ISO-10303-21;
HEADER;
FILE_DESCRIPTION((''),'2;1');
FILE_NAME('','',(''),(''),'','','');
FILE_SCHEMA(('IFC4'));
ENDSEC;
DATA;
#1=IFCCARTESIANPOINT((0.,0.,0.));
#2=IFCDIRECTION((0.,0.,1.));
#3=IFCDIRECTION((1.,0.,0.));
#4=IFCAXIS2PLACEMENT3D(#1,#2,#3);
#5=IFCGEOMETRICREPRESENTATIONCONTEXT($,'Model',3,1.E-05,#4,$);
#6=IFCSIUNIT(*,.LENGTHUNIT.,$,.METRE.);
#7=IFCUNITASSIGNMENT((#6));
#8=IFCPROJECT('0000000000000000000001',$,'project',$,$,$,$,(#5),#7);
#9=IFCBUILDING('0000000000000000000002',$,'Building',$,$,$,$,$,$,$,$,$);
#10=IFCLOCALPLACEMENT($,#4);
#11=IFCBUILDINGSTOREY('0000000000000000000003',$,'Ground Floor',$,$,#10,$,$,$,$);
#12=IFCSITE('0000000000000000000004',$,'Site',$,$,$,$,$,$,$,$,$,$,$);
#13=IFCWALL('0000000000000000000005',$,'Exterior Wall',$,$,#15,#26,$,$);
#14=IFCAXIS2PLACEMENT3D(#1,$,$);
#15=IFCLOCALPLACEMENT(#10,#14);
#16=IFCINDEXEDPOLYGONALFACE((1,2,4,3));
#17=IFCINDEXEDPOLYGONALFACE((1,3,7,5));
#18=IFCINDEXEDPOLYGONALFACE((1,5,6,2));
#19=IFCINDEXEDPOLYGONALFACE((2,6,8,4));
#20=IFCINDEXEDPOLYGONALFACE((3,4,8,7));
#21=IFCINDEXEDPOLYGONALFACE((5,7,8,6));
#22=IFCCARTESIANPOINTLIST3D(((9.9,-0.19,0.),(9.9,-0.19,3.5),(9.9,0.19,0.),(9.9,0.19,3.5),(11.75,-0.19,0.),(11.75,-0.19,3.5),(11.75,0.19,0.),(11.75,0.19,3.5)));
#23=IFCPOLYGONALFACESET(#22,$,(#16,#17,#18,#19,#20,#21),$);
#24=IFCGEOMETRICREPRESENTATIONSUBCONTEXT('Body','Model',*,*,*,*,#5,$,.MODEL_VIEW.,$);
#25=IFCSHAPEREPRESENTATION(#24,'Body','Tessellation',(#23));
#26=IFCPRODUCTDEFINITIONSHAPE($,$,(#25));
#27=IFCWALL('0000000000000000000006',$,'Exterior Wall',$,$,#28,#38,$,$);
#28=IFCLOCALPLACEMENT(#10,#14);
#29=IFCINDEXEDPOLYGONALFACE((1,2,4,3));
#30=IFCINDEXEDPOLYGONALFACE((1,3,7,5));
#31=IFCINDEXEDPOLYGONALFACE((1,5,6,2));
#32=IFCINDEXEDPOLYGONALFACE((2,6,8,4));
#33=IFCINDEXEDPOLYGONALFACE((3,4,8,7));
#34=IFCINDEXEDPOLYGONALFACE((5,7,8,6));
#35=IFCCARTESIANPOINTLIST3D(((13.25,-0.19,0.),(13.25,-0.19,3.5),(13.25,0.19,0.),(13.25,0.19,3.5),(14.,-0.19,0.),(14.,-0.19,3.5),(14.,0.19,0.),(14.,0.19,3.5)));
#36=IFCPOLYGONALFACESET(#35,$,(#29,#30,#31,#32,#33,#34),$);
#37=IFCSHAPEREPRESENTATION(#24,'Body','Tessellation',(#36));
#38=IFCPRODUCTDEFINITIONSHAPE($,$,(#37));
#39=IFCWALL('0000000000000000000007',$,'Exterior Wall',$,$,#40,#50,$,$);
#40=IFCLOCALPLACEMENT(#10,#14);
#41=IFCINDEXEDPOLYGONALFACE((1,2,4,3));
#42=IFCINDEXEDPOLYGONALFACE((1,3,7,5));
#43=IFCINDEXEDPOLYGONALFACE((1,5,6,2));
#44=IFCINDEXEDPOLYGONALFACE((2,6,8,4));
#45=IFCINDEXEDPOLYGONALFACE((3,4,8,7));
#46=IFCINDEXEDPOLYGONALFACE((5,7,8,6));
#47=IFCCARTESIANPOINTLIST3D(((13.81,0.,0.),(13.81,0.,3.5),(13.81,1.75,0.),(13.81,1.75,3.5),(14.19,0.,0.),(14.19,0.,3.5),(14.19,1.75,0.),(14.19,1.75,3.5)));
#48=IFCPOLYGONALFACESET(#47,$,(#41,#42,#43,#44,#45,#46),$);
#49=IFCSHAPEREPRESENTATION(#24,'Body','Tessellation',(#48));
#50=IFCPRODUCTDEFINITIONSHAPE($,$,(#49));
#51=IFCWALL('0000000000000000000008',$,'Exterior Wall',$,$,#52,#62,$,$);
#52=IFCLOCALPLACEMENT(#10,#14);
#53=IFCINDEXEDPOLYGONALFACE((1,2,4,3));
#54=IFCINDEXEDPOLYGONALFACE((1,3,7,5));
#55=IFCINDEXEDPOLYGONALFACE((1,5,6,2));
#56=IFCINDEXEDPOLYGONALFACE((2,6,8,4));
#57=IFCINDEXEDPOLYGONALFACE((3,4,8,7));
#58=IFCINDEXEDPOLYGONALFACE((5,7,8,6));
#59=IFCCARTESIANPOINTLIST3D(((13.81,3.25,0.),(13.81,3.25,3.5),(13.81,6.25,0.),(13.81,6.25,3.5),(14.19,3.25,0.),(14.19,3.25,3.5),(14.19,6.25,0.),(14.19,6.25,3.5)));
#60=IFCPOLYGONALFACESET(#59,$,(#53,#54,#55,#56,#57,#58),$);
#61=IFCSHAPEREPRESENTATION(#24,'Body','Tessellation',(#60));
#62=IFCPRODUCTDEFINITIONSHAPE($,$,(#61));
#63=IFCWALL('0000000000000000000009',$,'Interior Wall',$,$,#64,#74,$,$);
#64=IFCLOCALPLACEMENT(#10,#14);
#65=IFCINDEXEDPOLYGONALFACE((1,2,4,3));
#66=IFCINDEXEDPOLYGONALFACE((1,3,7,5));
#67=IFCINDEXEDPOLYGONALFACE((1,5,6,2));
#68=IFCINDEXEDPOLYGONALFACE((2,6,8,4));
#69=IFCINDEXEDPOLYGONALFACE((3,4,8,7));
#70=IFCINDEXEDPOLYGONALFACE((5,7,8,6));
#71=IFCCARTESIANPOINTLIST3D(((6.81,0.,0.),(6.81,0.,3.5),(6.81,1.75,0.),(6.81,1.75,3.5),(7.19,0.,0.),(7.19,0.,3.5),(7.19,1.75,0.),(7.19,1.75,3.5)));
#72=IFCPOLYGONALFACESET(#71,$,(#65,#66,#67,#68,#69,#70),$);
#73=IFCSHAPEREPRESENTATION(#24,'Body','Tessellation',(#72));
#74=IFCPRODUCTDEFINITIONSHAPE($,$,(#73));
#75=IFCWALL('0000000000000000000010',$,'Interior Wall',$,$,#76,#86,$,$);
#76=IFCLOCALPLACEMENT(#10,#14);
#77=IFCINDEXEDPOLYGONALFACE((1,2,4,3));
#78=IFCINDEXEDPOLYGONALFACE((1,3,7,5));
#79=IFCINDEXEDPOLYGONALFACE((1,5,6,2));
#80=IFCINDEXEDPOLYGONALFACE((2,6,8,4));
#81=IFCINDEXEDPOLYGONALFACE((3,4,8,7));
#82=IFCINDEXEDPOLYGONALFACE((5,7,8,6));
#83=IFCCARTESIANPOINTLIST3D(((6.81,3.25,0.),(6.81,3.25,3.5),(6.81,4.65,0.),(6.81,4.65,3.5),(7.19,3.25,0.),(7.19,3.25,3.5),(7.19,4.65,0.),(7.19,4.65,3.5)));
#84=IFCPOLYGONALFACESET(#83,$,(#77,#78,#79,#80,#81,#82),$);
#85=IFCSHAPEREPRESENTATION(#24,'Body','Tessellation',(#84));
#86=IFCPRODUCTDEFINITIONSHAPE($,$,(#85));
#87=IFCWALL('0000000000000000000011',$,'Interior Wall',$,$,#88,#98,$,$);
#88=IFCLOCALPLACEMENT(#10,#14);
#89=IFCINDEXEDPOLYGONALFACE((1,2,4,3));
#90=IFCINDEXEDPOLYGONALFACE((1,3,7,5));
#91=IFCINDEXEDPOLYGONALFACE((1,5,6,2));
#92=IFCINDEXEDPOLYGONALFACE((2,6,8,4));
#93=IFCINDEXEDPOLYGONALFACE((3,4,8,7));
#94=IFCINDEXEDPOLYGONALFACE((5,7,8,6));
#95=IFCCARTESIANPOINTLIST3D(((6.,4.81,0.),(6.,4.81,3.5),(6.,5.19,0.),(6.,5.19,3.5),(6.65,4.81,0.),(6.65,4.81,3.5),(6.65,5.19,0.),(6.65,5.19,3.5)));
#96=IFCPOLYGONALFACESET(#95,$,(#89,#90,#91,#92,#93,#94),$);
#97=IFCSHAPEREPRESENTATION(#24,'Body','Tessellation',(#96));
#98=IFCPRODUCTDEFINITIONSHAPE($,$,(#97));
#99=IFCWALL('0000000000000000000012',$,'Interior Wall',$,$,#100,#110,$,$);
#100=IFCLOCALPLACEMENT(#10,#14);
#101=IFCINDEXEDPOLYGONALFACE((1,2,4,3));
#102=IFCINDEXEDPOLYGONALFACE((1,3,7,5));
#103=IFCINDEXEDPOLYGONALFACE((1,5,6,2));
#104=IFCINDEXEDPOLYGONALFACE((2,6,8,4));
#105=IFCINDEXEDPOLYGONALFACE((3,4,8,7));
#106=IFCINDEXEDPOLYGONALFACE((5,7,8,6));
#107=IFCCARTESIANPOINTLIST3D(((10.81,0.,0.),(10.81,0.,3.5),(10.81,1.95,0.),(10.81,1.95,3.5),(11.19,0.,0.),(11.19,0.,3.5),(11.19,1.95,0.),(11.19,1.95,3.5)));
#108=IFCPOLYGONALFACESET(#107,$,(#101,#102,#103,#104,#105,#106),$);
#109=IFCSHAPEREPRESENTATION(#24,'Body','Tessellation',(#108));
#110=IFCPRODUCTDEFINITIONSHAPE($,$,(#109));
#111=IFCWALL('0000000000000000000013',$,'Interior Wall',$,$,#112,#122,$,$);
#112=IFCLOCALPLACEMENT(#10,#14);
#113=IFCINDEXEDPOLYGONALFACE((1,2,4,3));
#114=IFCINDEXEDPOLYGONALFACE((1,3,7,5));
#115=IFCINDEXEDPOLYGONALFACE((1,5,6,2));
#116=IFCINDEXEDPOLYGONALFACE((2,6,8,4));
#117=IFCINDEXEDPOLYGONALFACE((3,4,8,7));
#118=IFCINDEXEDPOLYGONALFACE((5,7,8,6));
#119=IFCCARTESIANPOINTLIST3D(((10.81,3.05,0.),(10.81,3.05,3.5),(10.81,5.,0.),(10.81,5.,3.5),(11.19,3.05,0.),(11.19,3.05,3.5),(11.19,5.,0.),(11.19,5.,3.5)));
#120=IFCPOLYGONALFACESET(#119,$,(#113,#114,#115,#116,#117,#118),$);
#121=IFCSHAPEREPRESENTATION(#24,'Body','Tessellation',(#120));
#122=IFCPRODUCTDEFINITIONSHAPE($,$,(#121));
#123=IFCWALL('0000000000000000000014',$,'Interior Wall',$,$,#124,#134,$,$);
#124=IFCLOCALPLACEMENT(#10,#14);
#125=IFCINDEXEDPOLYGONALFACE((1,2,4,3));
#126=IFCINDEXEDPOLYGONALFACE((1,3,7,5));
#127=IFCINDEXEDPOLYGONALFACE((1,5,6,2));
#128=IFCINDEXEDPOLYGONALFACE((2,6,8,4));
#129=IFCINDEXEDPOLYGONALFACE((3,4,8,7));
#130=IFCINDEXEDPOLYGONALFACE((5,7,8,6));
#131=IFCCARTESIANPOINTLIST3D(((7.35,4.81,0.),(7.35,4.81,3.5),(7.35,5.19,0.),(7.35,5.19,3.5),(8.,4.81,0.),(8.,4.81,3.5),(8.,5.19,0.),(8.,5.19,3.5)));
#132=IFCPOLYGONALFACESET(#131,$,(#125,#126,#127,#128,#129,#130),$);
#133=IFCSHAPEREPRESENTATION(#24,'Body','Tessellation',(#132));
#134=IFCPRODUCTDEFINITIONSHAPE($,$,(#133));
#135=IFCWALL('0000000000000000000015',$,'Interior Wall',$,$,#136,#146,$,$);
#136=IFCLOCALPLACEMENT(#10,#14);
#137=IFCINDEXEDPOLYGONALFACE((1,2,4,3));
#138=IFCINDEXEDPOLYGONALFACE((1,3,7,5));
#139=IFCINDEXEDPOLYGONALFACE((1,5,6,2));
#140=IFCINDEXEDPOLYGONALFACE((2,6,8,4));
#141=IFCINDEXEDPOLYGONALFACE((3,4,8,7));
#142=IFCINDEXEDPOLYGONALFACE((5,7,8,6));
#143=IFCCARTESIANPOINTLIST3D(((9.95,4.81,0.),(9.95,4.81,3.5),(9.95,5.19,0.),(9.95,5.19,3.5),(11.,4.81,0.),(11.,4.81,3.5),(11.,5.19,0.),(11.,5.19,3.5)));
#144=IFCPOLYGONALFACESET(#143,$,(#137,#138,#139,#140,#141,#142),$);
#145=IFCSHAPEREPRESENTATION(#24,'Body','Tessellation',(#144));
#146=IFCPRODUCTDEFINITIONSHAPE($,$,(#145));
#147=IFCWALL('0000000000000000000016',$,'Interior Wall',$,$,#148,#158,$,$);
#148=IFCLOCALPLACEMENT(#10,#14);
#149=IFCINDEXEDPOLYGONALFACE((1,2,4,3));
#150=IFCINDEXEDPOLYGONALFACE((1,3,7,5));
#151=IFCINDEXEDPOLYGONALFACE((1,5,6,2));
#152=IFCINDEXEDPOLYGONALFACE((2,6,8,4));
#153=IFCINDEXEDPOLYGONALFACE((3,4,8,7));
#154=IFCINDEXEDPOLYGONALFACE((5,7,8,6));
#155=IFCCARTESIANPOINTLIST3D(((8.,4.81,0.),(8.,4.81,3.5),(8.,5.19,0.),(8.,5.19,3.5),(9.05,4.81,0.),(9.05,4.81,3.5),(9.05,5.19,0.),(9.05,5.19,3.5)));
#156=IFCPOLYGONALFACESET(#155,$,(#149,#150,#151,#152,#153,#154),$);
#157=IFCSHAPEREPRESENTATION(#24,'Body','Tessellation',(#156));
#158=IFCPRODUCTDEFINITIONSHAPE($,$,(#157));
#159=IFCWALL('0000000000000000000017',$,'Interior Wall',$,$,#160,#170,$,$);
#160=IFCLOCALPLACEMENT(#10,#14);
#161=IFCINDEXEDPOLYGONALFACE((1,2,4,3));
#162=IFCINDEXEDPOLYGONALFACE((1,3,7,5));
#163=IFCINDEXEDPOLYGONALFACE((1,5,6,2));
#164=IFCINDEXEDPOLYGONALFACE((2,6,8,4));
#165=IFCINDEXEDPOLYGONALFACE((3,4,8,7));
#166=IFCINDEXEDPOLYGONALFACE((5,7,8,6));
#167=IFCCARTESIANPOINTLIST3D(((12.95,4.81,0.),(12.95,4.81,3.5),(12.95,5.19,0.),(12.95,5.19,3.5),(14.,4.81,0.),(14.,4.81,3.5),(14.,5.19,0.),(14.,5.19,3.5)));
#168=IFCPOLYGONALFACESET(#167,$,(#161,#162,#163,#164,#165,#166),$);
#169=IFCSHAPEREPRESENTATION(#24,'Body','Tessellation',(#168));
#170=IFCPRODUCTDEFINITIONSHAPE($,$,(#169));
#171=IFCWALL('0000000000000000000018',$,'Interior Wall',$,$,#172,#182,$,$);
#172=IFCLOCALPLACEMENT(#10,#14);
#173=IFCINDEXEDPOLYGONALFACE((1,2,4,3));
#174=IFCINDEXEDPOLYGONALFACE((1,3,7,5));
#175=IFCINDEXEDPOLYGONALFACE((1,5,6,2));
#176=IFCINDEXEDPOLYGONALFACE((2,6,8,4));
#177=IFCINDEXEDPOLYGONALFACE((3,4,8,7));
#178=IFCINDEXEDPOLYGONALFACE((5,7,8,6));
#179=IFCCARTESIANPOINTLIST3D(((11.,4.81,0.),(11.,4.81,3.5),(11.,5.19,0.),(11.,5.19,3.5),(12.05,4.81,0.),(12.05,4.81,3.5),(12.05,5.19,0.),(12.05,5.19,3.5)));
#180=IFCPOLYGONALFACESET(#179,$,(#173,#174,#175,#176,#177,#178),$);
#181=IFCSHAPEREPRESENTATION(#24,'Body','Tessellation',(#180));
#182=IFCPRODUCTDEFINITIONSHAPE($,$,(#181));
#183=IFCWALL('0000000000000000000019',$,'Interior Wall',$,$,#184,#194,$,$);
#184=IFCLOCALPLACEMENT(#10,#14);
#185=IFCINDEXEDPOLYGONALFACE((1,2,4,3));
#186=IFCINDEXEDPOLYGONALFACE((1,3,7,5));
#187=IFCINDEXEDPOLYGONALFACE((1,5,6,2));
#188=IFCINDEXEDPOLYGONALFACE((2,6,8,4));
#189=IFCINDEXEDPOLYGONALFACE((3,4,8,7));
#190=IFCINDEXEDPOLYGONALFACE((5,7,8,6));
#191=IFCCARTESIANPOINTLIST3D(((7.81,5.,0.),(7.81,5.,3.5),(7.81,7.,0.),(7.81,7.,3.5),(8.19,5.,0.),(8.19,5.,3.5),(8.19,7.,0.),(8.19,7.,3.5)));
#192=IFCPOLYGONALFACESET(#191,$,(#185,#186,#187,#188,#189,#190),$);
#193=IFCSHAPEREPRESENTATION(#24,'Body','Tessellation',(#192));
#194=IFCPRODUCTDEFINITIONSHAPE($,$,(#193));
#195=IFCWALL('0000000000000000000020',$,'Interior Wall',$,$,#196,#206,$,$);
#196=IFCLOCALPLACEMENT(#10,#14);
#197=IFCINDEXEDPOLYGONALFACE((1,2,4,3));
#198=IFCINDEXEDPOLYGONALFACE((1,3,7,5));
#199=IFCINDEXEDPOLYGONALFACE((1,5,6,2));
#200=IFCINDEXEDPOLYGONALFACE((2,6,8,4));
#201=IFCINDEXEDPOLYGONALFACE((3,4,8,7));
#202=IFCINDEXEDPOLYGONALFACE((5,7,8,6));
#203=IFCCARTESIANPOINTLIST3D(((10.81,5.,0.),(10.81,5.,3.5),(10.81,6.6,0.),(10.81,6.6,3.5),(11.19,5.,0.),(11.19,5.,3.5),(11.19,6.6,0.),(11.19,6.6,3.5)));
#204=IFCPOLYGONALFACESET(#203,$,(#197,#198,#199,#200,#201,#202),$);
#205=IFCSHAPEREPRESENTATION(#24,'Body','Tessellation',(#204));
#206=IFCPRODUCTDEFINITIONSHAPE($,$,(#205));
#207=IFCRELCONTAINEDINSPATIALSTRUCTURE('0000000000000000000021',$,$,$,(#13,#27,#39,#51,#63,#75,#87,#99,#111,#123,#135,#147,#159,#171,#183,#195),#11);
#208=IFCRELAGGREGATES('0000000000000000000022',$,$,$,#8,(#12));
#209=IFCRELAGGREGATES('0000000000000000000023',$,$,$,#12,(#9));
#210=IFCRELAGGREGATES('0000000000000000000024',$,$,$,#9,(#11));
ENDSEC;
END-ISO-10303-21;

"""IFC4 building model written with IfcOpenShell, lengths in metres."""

from ifc_helpers import new_model, si_unit, frame, origin_with_axes, place, context, subcontext, project, spatial, indexed_curve, outline, extrude, element, save


model = new_model("IFC4")

# Units and contexts
model_context = context("Model", 3, precision=1e-05, world=origin_with_axes())
body_context = subcontext(model_context, "Body", "Model", "MODEL_VIEW")
ifc_project = project(units=[si_unit("LENGTHUNIT", "METRE")], contexts=[model_context])

# Site, building, storey
site = spatial("IfcSite", under=ifc_project, Name="Site")
building = spatial("IfcBuilding", under=site, Name="Building")
storey_placement = place(None, origin_with_axes())
storey = spatial("IfcBuildingStorey", under=building, at=storey_placement, Name="Ground Floor")

# Walls
wall_1_placement = place(storey_placement, frame((9.9, 0.0, 0.0), z_axis=(0.0, 0.0, 1.0), x_axis=(1.0, 0.0, 0.0)))
element("IfcWall", 1, at=wall_1_placement, inside=storey, Name="Exterior Wall", context=body_context, shape_type="SweptSolid", body=[
    extrude(outline(indexed_curve([(0.0, 0.0), (0.0, 0.38), (1.85, 0.38), (1.85, 0.0), (0.0, 0.0)], self_intersect=False)), frame((0.0, -0.19, 0.0), z_axis=(0.0, 0.0, 1.0), x_axis=(1.0, 0.0, 0.0)), (0.0, 0.0, 1.0), 3.5),
])
wall_2_placement = place(storey_placement, frame((13.25, 0.0, 0.0), z_axis=(0.0, 0.0, 1.0), x_axis=(1.0, 0.0, 0.0)))
element("IfcWall", 2, at=wall_2_placement, inside=storey, Name="Exterior Wall", context=body_context, shape_type="SweptSolid", body=[
    extrude(outline(indexed_curve([(0.0, 0.0), (0.0, 0.38), (0.75, 0.38), (0.75, 0.0), (0.0, 0.0)], self_intersect=False)), frame((0.0, -0.19, 0.0), z_axis=(0.0, 0.0, 1.0), x_axis=(1.0, 0.0, 0.0)), (0.0, 0.0, 1.0), 3.5),
])
wall_3_placement = place(storey_placement, frame((14.0, 0.0, 0.0), z_axis=(0.0, 0.0, 1.0), x_axis=(0.0, 1.0, 0.0)))
element("IfcWall", 3, at=wall_3_placement, inside=storey, Name="Exterior Wall", context=body_context, shape_type="SweptSolid", body=[
    extrude(outline(indexed_curve([(0.0, 0.0), (0.0, 0.38), (1.75, 0.38), (1.75, 0.0), (0.0, 0.0)], self_intersect=False)), frame((0.0, -0.19, 0.0), z_axis=(0.0, 0.0, 1.0), x_axis=(1.0, 0.0, 0.0)), (0.0, 0.0, 1.0), 3.5),
])
wall_4_placement = place(storey_placement, frame((14.0, 3.25, 0.0), z_axis=(0.0, 0.0, 1.0), x_axis=(0.0, 1.0, 0.0)))
element("IfcWall", 4, at=wall_4_placement, inside=storey, Name="Exterior Wall", context=body_context, shape_type="SweptSolid", body=[
    extrude(outline(indexed_curve([(0.0, 0.0), (0.0, 0.38), (3.0, 0.38), (3.0, 0.0), (0.0, 0.0)], self_intersect=False)), frame((0.0, -0.19, 0.0), z_axis=(0.0, 0.0, 1.0), x_axis=(1.0, 0.0, 0.0)), (0.0, 0.0, 1.0), 3.5),
])
wall_5_placement = place(storey_placement, frame((7.0, 0.0, 0.0), z_axis=(0.0, 0.0, 1.0), x_axis=(0.0, 1.0, 0.0)))
element("IfcWall", 5, at=wall_5_placement, inside=storey, Name="Interior Wall", context=body_context, shape_type="SweptSolid", body=[
    extrude(outline(indexed_curve([(0.0, 0.0), (0.0, 0.38), (1.75, 0.38), (1.75, 0.0), (0.0, 0.0)], self_intersect=False)), frame((0.0, -0.19, 0.0), z_axis=(0.0, 0.0, 1.0), x_axis=(1.0, 0.0, 0.0)), (0.0, 0.0, 1.0), 3.5),
])
wall_6_placement = place(storey_placement, frame((7.0, 3.25, 0.0), z_axis=(0.0, 0.0, 1.0), x_axis=(0.0, 1.0, 0.0)))
element("IfcWall", 6, at=wall_6_placement, inside=storey, Name="Interior Wall", context=body_context, shape_type="SweptSolid", body=[
    extrude(outline(indexed_curve([(0.0, 0.0), (0.0, 0.38), (1.4, 0.38), (1.4, 0.0), (0.0, 0.0)], self_intersect=False)), frame((0.0, -0.19, 0.0), z_axis=(0.0, 0.0, 1.0), x_axis=(1.0, 0.0, 0.0)), (0.0, 0.0, 1.0), 3.5),
])
wall_7_placement = place(storey_placement, frame((6.65, 5.0, 0.0), z_axis=(0.0, 0.0, 1.0), x_axis=(-1.0, 0.0, 0.0)))
element("IfcWall", 7, at=wall_7_placement, inside=storey, Name="Interior Wall", context=body_context, shape_type="SweptSolid", body=[
    extrude(outline(indexed_curve([(0.0, 0.0), (0.0, 0.38), (0.65, 0.38), (0.65, 0.0), (0.0, 0.0)], self_intersect=False)), frame((0.0, -0.19, 0.0), z_axis=(0.0, 0.0, 1.0), x_axis=(1.0, 0.0, 0.0)), (0.0, 0.0, 1.0), 3.5),
])
wall_8_placement = place(storey_placement, frame((11.0, 0.0, 0.0), z_axis=(0.0, 0.0, 1.0), x_axis=(0.0, 1.0, 0.0)))
element("IfcWall", 8, at=wall_8_placement, inside=storey, Name="Interior Wall", context=body_context, shape_type="SweptSolid", body=[
    extrude(outline(indexed_curve([(0.0, 0.0), (0.0, 0.38), (1.95, 0.38), (1.95, 0.0), (0.0, 0.0)], self_intersect=False)), frame((0.0, -0.19, 0.0), z_axis=(0.0, 0.0, 1.0), x_axis=(1.0, 0.0, 0.0)), (0.0, 0.0, 1.0), 3.5),
])
wall_9_placement = place(storey_placement, frame((11.0, 3.05, 0.0), z_axis=(0.0, 0.0, 1.0), x_axis=(0.0, 1.0, 0.0)))
element("IfcWall", 9, at=wall_9_placement, inside=storey, Name="Interior Wall", context=body_context, shape_type="SweptSolid", body=[
    extrude(outline(indexed_curve([(0.0, 0.0), (0.0, 0.38), (1.95, 0.38), (1.95, 0.0), (0.0, 0.0)], self_intersect=False)), frame((0.0, -0.19, 0.0), z_axis=(0.0, 0.0, 1.0), x_axis=(1.0, 0.0, 0.0)), (0.0, 0.0, 1.0), 3.5),
])
wall_10_placement = place(storey_placement, frame((8.0, 5.0, 0.0), z_axis=(0.0, 0.0, 1.0), x_axis=(-1.0, 0.0, 0.0)))
element("IfcWall", 10, at=wall_10_placement, inside=storey, Name="Interior Wall", context=body_context, shape_type="SweptSolid", body=[
    extrude(outline(indexed_curve([(0.0, 0.0), (0.0, 0.38), (0.65, 0.38), (0.65, 0.0), (0.0, 0.0)], self_intersect=False)), frame((0.0, -0.19, 0.0), z_axis=(0.0, 0.0, 1.0), x_axis=(1.0, 0.0, 0.0)), (0.0, 0.0, 1.0), 3.5),
])
for number, where, z_axis, x_axis, name in (
    (11, (11.0, 5.0, 0.0), (0.0, 0.0, 1.0), (-1.0, 0.0, 0.0), "Interior Wall"),
    (12, (9.05, 5.0, 0.0), (0.0, 0.0, 1.0), (-1.0, 0.0, 0.0), "Interior Wall"),
    (13, (14.0, 5.0, 0.0), (0.0, 0.0, 1.0), (-1.0, 0.0, 0.0), "Interior Wall"),
    (14, (12.05, 5.0, 0.0), (0.0, 0.0, 1.0), (-1.0, 0.0, 0.0), "Interior Wall"),
):
    element("IfcWall", number, at=place(storey_placement, frame(where, z_axis=z_axis, x_axis=x_axis)), inside=storey, Name=name, context=body_context, shape_type="SweptSolid", body=[
        extrude(outline(indexed_curve([(0.0, 0.0), (0.0, 0.38), (1.05, 0.38), (1.05, 0.0), (0.0, 0.0)], self_intersect=False)), frame((0.0, -0.19, 0.0), z_axis=(0.0, 0.0, 1.0), x_axis=(1.0, 0.0, 0.0)), (0.0, 0.0, 1.0), 3.5),
    ])
wall_11_placement = place(storey_placement, frame((8.0, 5.0, 0.0), z_axis=(0.0, 0.0, 1.0), x_axis=(0.0, 1.0, 0.0)))
element("IfcWall", 15, at=wall_11_placement, inside=storey, Name="Interior Wall", context=body_context, shape_type="SweptSolid", body=[
    extrude(outline(indexed_curve([(0.0, 0.0), (0.0, 0.38), (2.0, 0.38), (2.0, 0.0), (0.0, 0.0)], self_intersect=False)), frame((0.0, -0.19, 0.0), z_axis=(0.0, 0.0, 1.0), x_axis=(1.0, 0.0, 0.0)), (0.0, 0.0, 1.0), 3.5),
])
wall_12_placement = place(storey_placement, frame((11.0, 5.0, 0.0), z_axis=(0.0, 0.0, 1.0), x_axis=(0.0, 1.0, 0.0)))
element("IfcWall", 16, at=wall_12_placement, inside=storey, Name="Interior Wall", context=body_context, shape_type="SweptSolid", body=[
    extrude(outline(indexed_curve([(0.0, 0.0), (0.0, 0.38), (1.6, 0.38), (1.6, 0.0), (0.0, 0.0)], self_intersect=False)), frame((0.0, -0.19, 0.0), z_axis=(0.0, 0.0, 1.0), x_axis=(1.0, 0.0, 0.0)), (0.0, 0.0, 1.0), 3.5),
])

save(model, "model.ifc")
